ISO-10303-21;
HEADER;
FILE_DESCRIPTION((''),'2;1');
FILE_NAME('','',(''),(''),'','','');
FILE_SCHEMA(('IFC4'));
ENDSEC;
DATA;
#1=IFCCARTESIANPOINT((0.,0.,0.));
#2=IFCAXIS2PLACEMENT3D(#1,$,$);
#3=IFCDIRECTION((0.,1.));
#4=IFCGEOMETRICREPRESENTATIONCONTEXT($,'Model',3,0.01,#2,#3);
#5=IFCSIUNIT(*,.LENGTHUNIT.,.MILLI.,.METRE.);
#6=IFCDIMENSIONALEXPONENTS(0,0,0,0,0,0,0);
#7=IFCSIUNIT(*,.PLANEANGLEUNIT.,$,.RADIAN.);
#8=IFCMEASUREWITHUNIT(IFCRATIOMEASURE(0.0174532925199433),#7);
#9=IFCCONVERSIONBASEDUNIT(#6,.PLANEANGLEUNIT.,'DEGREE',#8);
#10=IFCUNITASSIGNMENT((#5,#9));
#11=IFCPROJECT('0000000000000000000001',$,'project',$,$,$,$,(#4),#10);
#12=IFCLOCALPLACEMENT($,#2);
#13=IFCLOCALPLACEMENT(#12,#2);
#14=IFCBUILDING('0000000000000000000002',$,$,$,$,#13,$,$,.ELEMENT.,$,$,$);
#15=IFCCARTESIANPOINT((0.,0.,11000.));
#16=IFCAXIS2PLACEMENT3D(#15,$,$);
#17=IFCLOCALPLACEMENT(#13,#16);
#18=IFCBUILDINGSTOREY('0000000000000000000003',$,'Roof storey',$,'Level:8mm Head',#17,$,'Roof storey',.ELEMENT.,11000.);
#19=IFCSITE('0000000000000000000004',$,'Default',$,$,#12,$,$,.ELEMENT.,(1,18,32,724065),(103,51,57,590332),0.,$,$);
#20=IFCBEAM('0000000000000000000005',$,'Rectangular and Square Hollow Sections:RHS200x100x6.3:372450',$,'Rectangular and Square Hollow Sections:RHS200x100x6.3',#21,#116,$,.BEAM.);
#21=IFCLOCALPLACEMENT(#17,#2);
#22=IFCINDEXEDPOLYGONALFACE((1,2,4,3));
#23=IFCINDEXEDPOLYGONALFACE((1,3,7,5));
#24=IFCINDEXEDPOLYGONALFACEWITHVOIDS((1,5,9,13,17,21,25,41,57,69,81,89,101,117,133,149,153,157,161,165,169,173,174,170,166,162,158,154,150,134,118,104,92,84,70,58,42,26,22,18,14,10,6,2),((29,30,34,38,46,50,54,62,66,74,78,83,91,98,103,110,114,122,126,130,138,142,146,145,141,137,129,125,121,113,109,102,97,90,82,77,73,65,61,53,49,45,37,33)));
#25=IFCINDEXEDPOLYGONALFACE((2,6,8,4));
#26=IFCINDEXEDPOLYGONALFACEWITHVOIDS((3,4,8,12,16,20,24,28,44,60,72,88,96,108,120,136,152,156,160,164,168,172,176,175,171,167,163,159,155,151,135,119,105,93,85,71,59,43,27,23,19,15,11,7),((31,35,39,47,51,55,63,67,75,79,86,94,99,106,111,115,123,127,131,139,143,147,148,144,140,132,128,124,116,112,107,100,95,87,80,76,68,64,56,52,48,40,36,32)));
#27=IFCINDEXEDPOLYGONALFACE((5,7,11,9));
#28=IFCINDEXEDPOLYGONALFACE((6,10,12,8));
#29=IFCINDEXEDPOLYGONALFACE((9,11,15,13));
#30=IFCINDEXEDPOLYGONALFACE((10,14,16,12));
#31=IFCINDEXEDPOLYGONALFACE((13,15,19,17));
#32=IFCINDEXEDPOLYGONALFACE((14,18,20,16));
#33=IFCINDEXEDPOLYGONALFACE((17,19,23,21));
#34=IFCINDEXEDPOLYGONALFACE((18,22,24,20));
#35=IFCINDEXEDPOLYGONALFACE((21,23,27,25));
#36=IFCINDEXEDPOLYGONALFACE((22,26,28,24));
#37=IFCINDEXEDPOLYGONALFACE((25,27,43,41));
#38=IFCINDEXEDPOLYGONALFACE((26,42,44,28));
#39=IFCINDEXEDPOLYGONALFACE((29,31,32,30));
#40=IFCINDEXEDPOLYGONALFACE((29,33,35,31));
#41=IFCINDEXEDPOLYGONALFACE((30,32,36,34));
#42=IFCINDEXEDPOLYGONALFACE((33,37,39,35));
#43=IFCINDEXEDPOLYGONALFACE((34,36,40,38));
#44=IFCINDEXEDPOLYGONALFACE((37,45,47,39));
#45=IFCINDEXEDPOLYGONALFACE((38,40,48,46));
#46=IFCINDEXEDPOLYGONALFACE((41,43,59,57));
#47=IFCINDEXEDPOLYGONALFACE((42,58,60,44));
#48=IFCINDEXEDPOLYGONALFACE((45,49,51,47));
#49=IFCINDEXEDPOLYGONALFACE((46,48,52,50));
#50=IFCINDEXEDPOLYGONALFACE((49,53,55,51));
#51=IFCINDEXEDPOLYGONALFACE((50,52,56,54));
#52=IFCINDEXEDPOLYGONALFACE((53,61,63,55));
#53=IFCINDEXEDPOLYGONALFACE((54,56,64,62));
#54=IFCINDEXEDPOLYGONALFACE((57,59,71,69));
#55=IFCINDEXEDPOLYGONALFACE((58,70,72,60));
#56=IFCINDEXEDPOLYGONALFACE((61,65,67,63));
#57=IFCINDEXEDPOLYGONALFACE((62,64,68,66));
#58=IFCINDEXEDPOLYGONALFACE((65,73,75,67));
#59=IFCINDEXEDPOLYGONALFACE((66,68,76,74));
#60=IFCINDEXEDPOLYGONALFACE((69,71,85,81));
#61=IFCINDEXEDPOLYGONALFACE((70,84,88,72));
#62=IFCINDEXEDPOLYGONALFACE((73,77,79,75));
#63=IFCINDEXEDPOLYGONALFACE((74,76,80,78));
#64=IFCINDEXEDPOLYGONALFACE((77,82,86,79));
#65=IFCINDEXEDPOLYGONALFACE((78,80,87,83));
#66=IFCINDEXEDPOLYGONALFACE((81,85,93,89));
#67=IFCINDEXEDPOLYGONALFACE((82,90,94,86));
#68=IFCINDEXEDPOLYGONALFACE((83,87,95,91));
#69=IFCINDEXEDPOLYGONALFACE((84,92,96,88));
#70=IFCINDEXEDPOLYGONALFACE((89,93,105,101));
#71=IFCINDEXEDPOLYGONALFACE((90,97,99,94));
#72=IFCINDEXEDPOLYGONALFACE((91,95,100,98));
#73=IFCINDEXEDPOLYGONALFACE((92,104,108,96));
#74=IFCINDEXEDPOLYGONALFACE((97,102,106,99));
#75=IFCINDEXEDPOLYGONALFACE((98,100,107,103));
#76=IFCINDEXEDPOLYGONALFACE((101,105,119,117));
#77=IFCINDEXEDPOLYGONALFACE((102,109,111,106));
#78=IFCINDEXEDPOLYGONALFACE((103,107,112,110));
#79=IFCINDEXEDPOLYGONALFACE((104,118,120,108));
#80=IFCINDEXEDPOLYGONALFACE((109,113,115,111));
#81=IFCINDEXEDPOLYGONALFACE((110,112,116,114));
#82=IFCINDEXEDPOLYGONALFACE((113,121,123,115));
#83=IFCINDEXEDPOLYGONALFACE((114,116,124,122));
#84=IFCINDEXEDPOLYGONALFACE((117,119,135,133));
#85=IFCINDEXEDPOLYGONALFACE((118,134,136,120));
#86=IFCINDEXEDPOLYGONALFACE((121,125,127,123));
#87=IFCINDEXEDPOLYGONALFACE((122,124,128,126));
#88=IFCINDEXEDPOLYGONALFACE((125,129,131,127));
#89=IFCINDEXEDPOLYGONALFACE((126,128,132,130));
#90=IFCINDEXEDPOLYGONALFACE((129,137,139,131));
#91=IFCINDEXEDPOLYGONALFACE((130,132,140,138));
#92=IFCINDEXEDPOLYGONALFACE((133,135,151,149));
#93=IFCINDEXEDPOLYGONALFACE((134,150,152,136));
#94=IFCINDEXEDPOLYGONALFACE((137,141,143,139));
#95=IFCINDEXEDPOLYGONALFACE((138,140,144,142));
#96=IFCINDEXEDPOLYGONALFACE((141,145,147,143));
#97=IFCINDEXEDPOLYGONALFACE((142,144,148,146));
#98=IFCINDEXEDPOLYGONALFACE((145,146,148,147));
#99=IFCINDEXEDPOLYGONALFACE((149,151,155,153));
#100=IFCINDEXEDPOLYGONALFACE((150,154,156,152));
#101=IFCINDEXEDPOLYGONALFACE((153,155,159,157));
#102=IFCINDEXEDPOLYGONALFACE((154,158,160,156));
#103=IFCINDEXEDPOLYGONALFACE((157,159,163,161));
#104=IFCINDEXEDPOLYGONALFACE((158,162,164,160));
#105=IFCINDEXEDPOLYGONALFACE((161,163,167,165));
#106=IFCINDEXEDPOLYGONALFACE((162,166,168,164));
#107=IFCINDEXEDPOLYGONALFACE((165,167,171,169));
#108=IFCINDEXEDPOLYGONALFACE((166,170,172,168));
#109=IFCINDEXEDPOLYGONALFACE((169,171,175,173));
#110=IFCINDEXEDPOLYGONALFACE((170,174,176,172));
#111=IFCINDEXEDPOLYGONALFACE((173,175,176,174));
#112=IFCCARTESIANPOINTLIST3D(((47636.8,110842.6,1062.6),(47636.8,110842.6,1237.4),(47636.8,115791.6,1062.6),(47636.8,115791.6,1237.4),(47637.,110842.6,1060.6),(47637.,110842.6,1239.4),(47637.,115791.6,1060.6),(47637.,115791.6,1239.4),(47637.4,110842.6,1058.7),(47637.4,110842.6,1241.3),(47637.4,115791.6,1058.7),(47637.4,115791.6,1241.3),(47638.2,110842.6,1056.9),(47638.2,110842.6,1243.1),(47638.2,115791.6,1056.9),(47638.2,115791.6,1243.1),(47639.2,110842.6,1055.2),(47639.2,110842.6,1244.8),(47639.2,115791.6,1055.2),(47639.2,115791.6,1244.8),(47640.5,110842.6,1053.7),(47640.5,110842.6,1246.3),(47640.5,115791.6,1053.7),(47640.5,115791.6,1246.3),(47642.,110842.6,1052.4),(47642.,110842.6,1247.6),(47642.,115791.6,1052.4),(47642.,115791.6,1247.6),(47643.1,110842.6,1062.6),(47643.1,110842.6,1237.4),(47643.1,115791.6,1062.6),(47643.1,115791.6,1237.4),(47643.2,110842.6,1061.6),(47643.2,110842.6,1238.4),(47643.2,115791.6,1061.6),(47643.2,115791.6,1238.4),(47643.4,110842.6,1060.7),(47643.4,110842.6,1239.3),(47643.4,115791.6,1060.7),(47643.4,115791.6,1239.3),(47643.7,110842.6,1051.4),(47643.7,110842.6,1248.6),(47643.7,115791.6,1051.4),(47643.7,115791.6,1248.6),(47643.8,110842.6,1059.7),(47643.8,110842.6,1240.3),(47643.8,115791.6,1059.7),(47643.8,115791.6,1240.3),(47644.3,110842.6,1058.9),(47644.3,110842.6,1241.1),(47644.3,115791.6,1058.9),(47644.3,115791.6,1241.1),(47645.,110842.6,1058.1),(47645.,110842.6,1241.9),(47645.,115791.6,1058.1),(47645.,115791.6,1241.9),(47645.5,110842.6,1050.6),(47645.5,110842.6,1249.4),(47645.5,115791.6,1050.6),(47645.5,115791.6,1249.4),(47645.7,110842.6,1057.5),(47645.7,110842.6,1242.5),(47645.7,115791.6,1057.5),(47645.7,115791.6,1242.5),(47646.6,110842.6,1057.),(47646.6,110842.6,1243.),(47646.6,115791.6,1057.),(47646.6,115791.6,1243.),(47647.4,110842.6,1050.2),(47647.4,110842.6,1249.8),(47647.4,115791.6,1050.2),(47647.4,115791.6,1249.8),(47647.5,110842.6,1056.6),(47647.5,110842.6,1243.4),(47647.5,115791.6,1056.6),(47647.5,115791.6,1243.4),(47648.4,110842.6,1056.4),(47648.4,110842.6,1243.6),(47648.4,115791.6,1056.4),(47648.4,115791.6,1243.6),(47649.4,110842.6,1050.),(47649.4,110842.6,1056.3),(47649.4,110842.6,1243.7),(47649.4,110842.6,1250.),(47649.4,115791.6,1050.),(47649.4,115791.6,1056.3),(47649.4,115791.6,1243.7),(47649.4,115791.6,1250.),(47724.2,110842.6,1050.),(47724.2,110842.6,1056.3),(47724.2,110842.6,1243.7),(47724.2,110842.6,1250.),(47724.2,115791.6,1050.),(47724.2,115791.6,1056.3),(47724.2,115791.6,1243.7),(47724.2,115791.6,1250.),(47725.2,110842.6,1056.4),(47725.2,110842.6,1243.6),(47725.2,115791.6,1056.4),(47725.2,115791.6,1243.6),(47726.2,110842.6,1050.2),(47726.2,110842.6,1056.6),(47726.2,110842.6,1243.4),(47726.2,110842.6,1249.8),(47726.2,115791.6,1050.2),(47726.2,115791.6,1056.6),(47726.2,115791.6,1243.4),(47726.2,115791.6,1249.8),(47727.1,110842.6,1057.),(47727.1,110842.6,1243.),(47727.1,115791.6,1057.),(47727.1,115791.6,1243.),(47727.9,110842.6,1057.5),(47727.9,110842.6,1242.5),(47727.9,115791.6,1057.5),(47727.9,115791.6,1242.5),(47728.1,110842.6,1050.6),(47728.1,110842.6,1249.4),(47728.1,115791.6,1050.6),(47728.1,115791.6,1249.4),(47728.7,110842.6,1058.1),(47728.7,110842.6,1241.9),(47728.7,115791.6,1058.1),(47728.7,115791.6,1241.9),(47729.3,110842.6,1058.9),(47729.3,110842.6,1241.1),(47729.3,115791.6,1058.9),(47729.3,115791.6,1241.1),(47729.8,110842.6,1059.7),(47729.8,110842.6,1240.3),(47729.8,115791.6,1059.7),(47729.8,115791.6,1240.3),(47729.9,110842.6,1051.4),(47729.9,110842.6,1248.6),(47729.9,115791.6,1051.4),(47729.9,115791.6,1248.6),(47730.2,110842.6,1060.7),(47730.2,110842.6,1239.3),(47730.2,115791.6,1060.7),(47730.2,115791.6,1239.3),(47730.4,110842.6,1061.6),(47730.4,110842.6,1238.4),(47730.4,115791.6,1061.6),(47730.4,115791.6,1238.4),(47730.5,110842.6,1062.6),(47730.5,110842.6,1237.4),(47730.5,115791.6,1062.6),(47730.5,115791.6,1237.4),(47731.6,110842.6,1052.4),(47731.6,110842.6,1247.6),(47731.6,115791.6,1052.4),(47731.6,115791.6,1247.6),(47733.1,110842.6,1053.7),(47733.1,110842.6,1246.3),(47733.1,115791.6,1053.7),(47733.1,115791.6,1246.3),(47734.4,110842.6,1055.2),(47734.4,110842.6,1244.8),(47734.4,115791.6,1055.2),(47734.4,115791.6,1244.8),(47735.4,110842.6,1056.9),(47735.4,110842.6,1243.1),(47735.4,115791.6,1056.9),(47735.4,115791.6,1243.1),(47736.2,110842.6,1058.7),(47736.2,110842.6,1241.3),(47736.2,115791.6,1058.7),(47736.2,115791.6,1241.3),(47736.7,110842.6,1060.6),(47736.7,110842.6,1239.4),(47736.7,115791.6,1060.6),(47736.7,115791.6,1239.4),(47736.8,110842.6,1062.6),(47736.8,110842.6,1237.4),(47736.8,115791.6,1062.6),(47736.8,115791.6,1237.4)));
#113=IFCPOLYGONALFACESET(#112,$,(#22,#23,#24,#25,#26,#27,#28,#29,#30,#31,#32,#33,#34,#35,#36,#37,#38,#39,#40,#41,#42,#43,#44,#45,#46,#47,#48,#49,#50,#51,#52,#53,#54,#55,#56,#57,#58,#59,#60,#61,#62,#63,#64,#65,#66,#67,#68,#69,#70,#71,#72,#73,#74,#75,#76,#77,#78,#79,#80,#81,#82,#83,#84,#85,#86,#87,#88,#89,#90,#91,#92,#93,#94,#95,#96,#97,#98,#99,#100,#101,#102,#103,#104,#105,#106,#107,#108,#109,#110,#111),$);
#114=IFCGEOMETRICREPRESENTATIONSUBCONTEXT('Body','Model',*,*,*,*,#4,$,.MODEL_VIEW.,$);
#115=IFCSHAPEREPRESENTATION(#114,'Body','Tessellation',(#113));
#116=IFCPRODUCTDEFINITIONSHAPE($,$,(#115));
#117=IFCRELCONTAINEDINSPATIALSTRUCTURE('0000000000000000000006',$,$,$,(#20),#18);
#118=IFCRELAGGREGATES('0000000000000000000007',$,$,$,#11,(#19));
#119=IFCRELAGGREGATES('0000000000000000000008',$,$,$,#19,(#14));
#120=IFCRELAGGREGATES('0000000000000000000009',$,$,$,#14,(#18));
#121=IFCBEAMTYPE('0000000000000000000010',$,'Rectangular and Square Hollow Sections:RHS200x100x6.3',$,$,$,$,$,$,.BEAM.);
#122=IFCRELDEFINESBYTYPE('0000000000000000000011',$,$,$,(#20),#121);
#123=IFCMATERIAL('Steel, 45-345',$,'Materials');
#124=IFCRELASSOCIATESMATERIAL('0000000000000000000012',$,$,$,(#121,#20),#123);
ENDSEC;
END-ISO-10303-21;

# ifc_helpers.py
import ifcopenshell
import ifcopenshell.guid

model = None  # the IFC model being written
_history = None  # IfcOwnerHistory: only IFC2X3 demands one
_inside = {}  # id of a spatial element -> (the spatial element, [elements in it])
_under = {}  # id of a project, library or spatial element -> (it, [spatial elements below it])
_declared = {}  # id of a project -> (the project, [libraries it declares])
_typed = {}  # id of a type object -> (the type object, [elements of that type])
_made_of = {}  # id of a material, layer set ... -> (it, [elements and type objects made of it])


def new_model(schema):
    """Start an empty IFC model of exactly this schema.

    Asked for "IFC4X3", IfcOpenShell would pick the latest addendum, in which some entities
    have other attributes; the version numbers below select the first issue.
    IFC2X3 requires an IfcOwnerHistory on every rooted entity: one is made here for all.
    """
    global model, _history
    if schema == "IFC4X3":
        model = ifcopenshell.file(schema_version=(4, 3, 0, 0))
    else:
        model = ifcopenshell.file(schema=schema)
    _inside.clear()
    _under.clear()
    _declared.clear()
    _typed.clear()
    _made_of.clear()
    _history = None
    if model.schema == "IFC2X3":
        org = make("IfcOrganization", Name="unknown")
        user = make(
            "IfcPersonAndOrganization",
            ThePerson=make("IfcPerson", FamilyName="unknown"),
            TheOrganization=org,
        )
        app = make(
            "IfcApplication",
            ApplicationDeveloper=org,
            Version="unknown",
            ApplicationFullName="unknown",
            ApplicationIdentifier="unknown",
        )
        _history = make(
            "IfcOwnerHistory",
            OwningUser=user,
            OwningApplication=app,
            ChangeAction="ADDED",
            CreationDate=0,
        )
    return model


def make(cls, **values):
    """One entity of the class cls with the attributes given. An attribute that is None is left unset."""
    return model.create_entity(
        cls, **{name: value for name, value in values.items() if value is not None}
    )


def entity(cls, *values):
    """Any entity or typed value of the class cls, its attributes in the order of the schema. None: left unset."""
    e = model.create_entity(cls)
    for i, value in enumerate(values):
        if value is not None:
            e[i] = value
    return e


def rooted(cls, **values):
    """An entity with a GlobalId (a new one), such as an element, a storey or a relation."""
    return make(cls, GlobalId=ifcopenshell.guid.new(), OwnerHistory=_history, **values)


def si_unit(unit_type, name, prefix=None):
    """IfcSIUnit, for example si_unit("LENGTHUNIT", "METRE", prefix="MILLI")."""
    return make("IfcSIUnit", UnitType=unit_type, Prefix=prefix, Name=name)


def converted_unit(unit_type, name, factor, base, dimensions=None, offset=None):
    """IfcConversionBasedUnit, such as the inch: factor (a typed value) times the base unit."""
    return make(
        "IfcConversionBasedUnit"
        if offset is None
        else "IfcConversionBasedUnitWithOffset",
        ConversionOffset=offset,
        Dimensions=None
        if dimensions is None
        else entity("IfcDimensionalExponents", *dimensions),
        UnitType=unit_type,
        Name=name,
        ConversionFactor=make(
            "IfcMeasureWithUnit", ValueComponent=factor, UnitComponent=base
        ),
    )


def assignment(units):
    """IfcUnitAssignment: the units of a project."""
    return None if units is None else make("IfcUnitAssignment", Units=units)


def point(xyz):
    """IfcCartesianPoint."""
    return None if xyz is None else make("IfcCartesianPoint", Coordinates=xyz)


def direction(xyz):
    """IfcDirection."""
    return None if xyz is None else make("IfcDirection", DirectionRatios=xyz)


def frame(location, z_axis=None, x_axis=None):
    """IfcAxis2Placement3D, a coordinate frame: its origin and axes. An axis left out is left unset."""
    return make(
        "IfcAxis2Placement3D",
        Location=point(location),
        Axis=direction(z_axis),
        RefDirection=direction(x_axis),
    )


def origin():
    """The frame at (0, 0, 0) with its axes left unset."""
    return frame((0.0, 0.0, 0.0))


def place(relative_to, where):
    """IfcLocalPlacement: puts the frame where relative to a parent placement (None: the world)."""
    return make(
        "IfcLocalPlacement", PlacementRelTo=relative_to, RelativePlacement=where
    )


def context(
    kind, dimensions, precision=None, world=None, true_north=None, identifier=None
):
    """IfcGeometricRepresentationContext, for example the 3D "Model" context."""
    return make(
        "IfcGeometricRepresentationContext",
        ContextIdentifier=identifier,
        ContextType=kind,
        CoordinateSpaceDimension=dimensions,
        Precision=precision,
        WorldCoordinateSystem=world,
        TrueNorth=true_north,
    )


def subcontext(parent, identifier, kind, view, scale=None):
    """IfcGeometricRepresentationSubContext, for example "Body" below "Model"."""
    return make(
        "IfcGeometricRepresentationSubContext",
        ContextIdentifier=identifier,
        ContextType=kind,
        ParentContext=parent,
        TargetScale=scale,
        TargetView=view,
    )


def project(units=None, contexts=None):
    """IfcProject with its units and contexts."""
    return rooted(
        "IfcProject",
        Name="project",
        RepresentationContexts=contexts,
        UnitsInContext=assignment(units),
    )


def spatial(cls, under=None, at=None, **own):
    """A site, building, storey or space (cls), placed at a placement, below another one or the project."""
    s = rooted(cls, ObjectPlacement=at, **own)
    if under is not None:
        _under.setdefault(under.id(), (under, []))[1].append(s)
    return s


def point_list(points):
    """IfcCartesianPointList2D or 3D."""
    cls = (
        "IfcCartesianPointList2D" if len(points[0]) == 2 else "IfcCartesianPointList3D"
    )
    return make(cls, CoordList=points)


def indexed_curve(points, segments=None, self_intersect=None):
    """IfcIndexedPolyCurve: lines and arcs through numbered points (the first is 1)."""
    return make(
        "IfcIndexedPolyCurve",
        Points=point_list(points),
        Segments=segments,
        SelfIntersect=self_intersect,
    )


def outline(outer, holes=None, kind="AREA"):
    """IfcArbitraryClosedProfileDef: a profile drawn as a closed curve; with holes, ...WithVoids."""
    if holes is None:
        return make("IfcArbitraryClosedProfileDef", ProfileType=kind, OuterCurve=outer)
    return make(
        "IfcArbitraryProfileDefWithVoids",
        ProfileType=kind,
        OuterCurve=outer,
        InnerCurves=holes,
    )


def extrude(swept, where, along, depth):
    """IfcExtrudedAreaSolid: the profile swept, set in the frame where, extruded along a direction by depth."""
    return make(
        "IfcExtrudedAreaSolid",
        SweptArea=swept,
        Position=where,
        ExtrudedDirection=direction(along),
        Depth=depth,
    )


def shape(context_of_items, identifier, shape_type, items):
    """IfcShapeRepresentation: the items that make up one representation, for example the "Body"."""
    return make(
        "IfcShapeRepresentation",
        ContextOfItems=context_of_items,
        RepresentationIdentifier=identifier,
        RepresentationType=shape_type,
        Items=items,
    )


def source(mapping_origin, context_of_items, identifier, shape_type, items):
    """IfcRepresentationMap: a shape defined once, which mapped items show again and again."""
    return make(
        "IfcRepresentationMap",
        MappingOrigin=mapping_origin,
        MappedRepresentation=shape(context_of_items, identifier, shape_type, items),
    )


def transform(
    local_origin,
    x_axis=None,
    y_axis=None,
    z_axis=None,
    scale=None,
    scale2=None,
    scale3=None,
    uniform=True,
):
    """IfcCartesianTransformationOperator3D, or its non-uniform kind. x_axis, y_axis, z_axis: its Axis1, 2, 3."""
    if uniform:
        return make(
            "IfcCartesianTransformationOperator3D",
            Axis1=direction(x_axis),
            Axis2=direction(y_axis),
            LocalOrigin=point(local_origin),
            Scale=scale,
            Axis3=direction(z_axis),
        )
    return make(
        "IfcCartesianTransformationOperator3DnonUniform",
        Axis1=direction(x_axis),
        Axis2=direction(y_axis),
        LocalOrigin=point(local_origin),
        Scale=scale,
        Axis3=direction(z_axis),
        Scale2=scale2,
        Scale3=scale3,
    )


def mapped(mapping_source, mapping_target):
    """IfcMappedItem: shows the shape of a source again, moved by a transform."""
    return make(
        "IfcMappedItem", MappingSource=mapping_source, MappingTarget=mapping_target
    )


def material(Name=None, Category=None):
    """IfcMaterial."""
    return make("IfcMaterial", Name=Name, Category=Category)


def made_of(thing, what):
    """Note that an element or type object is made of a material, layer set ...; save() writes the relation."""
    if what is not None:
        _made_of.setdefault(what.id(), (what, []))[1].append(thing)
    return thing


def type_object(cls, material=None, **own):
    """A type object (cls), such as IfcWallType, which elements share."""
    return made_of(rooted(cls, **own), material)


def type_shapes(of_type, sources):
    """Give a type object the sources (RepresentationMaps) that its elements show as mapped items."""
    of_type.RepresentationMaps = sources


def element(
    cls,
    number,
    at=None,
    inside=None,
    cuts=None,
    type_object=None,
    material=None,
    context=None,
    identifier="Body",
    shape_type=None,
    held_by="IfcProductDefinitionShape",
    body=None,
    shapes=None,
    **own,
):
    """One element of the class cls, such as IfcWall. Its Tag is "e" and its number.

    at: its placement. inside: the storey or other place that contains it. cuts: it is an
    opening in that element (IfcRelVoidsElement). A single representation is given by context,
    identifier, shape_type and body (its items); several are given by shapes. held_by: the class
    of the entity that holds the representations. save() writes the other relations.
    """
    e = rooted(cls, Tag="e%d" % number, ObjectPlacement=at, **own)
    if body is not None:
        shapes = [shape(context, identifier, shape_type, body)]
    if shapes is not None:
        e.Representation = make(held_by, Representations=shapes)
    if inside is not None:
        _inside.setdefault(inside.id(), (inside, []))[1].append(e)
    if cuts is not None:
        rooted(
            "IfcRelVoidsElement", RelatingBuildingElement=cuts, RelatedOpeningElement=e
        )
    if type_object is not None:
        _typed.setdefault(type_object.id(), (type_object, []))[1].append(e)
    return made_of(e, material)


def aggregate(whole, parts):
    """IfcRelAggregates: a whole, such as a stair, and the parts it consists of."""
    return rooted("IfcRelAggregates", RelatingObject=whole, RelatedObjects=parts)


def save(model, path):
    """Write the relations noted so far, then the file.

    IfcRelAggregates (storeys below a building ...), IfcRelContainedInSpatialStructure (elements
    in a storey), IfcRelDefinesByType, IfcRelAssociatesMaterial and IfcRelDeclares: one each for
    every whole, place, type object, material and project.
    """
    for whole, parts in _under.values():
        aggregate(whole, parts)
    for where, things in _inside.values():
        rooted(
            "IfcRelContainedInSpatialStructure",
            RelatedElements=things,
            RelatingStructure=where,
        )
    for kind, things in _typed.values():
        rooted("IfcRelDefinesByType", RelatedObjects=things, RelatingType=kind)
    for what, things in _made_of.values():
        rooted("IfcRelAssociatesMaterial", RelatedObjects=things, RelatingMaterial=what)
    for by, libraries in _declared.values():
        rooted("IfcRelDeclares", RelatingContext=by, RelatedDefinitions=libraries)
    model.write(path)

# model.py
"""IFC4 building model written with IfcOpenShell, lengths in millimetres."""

from ifc_helpers import new_model, entity, si_unit, converted_unit, direction, frame, origin, place, context, subcontext, project, spatial, indexed_curve, outline, extrude, source, transform, mapped, material, type_object, type_shapes, element, save


model = new_model("IFC4")

# Units and contexts
model_context = context("Model", 3, precision=0.01, world=origin(), true_north=direction((0.0, 1.0)))
body_context = subcontext(model_context, "Body", "Model", "MODEL_VIEW")
ifc_project = project(units=[si_unit("LENGTHUNIT", "METRE", prefix="MILLI"), converted_unit("PLANEANGLEUNIT", "DEGREE", entity("IfcRatioMeasure", 0.0174532925199433), si_unit("PLANEANGLEUNIT", "RADIAN"), dimensions=[0, 0, 0, 0, 0, 0, 0])], contexts=[model_context])

# Site, building, storey
site_placement = place(None, origin())
site = spatial("IfcSite", under=ifc_project, at=site_placement, Name="Default", CompositionType="ELEMENT", RefLatitude=(1, 18, 32, 724065), RefLongitude=(103, 51, 57, 590332), RefElevation=0.0)
building_placement = place(site_placement, origin())
building = spatial("IfcBuilding", under=site, at=building_placement, CompositionType="ELEMENT")
storey_placement = place(building_placement, frame((0.0, 0.0, 11000.0)))
storey = spatial("IfcBuildingStorey", under=building, at=storey_placement, Name="Roof storey", ObjectType="Level:8mm Head", LongName="Roof storey", CompositionType="ELEMENT", Elevation=11000.0)

# Shared definitions
ifc_material = material(Name="Steel, 45-345", Category="Materials")

# Beam
beam_type_1 = type_object("IfcBeamType", Name="Rectangular and Square Hollow Sections:RHS200x100x6.3", PredefinedType="BEAM", material=ifc_material)
shared_shape_1 = source(origin(), body_context, "Body", "SweptSolid", [
    extrude(outline(indexed_curve([(87.4, -50.0), (89.4, -49.8), (91.3, -49.4), (93.1, -48.6), (94.8, -47.6), (96.3, -46.3), (97.6, -44.8), (98.6, -43.1), (99.4, -41.3), (99.8, -39.4), (100.0, -37.4), (100.0, 37.4), (99.8, 39.4), (99.4, 41.3), (98.6, 43.1), (97.6, 44.8), (96.3, 46.3), (94.8, 47.6), (93.1, 48.6), (91.3, 49.4), (89.4, 49.8), (87.4, 50.0), (-87.4, 50.0), (-89.4, 49.8), (-91.3, 49.4), (-93.1, 48.6), (-94.8, 47.6), (-96.3, 46.3), (-97.6, 44.8), (-98.6, 43.1), (-99.4, 41.3), (-99.8, 39.4), (-100.0, 37.4), (-100.0, -37.4), (-99.8, -39.4), (-99.4, -41.3), (-98.6, -43.1), (-97.6, -44.8), (-96.3, -46.3), (-94.8, -47.6), (-93.1, -48.6), (-91.3, -49.4), (-89.4, -49.8), (-87.4, -50.0), (87.4, -50.0)], self_intersect=False), holes=[indexed_curve([(93.7, 37.4), (93.7, -37.4), (93.6, -38.4), (93.4, -39.3), (93.0, -40.3), (92.5, -41.1), (91.9, -41.9), (91.1, -42.5), (90.3, -43.0), (89.3, -43.4), (88.4, -43.6), (87.4, -43.7), (-87.4, -43.7), (-88.4, -43.6), (-89.3, -43.4), (-90.3, -43.0), (-91.1, -42.5), (-91.9, -41.9), (-92.5, -41.1), (-93.0, -40.3), (-93.4, -39.3), (-93.6, -38.4), (-93.7, -37.4), (-93.7, 37.4), (-93.6, 38.4), (-93.4, 39.3), (-93.0, 40.3), (-92.5, 41.1), (-91.9, 41.9), (-91.1, 42.5), (-90.3, 43.0), (-89.3, 43.4), (-88.4, 43.6), (-87.4, 43.7), (87.4, 43.7), (88.4, 43.6), (89.3, 43.4), (90.3, 43.0), (91.1, 42.5), (91.9, 41.9), (92.5, 41.1), (93.0, 40.3), (93.4, 39.3), (93.6, 38.4), (93.7, 37.4)], self_intersect=False)]), frame((-2474.5, 0.0, 0.0), z_axis=(1.0, 0.0, 0.0), x_axis=(0.0, 0.0, 1.0)), (0.0, 0.0, 1.0), 4949.0),
])
type_shapes(beam_type_1, [shared_shape_1])
for number, where, z_axis, x_axis, name in (
    (1, (47686.8, 113317.1, 1150.0), (0.0, 0.0, 1.0), (0.0, 1.0, 0.0), "Rectangular and Square Hollow Sections:RHS200x100x6.3:372450"),
):
    element("IfcBeam", number, at=place(storey_placement, frame(where, z_axis=z_axis, x_axis=x_axis)), inside=storey, type_object=beam_type_1, material=ifc_material, Name=name, ObjectType="Rectangular and Square Hollow Sections:RHS200x100x6.3", PredefinedType="BEAM", context=body_context, shape_type="MappedRepresentation", body=[
        mapped(shared_shape_1, transform((0.0, 0.0, 0.0), scale=1.0)),
    ])

save(model, "model.ifc")
